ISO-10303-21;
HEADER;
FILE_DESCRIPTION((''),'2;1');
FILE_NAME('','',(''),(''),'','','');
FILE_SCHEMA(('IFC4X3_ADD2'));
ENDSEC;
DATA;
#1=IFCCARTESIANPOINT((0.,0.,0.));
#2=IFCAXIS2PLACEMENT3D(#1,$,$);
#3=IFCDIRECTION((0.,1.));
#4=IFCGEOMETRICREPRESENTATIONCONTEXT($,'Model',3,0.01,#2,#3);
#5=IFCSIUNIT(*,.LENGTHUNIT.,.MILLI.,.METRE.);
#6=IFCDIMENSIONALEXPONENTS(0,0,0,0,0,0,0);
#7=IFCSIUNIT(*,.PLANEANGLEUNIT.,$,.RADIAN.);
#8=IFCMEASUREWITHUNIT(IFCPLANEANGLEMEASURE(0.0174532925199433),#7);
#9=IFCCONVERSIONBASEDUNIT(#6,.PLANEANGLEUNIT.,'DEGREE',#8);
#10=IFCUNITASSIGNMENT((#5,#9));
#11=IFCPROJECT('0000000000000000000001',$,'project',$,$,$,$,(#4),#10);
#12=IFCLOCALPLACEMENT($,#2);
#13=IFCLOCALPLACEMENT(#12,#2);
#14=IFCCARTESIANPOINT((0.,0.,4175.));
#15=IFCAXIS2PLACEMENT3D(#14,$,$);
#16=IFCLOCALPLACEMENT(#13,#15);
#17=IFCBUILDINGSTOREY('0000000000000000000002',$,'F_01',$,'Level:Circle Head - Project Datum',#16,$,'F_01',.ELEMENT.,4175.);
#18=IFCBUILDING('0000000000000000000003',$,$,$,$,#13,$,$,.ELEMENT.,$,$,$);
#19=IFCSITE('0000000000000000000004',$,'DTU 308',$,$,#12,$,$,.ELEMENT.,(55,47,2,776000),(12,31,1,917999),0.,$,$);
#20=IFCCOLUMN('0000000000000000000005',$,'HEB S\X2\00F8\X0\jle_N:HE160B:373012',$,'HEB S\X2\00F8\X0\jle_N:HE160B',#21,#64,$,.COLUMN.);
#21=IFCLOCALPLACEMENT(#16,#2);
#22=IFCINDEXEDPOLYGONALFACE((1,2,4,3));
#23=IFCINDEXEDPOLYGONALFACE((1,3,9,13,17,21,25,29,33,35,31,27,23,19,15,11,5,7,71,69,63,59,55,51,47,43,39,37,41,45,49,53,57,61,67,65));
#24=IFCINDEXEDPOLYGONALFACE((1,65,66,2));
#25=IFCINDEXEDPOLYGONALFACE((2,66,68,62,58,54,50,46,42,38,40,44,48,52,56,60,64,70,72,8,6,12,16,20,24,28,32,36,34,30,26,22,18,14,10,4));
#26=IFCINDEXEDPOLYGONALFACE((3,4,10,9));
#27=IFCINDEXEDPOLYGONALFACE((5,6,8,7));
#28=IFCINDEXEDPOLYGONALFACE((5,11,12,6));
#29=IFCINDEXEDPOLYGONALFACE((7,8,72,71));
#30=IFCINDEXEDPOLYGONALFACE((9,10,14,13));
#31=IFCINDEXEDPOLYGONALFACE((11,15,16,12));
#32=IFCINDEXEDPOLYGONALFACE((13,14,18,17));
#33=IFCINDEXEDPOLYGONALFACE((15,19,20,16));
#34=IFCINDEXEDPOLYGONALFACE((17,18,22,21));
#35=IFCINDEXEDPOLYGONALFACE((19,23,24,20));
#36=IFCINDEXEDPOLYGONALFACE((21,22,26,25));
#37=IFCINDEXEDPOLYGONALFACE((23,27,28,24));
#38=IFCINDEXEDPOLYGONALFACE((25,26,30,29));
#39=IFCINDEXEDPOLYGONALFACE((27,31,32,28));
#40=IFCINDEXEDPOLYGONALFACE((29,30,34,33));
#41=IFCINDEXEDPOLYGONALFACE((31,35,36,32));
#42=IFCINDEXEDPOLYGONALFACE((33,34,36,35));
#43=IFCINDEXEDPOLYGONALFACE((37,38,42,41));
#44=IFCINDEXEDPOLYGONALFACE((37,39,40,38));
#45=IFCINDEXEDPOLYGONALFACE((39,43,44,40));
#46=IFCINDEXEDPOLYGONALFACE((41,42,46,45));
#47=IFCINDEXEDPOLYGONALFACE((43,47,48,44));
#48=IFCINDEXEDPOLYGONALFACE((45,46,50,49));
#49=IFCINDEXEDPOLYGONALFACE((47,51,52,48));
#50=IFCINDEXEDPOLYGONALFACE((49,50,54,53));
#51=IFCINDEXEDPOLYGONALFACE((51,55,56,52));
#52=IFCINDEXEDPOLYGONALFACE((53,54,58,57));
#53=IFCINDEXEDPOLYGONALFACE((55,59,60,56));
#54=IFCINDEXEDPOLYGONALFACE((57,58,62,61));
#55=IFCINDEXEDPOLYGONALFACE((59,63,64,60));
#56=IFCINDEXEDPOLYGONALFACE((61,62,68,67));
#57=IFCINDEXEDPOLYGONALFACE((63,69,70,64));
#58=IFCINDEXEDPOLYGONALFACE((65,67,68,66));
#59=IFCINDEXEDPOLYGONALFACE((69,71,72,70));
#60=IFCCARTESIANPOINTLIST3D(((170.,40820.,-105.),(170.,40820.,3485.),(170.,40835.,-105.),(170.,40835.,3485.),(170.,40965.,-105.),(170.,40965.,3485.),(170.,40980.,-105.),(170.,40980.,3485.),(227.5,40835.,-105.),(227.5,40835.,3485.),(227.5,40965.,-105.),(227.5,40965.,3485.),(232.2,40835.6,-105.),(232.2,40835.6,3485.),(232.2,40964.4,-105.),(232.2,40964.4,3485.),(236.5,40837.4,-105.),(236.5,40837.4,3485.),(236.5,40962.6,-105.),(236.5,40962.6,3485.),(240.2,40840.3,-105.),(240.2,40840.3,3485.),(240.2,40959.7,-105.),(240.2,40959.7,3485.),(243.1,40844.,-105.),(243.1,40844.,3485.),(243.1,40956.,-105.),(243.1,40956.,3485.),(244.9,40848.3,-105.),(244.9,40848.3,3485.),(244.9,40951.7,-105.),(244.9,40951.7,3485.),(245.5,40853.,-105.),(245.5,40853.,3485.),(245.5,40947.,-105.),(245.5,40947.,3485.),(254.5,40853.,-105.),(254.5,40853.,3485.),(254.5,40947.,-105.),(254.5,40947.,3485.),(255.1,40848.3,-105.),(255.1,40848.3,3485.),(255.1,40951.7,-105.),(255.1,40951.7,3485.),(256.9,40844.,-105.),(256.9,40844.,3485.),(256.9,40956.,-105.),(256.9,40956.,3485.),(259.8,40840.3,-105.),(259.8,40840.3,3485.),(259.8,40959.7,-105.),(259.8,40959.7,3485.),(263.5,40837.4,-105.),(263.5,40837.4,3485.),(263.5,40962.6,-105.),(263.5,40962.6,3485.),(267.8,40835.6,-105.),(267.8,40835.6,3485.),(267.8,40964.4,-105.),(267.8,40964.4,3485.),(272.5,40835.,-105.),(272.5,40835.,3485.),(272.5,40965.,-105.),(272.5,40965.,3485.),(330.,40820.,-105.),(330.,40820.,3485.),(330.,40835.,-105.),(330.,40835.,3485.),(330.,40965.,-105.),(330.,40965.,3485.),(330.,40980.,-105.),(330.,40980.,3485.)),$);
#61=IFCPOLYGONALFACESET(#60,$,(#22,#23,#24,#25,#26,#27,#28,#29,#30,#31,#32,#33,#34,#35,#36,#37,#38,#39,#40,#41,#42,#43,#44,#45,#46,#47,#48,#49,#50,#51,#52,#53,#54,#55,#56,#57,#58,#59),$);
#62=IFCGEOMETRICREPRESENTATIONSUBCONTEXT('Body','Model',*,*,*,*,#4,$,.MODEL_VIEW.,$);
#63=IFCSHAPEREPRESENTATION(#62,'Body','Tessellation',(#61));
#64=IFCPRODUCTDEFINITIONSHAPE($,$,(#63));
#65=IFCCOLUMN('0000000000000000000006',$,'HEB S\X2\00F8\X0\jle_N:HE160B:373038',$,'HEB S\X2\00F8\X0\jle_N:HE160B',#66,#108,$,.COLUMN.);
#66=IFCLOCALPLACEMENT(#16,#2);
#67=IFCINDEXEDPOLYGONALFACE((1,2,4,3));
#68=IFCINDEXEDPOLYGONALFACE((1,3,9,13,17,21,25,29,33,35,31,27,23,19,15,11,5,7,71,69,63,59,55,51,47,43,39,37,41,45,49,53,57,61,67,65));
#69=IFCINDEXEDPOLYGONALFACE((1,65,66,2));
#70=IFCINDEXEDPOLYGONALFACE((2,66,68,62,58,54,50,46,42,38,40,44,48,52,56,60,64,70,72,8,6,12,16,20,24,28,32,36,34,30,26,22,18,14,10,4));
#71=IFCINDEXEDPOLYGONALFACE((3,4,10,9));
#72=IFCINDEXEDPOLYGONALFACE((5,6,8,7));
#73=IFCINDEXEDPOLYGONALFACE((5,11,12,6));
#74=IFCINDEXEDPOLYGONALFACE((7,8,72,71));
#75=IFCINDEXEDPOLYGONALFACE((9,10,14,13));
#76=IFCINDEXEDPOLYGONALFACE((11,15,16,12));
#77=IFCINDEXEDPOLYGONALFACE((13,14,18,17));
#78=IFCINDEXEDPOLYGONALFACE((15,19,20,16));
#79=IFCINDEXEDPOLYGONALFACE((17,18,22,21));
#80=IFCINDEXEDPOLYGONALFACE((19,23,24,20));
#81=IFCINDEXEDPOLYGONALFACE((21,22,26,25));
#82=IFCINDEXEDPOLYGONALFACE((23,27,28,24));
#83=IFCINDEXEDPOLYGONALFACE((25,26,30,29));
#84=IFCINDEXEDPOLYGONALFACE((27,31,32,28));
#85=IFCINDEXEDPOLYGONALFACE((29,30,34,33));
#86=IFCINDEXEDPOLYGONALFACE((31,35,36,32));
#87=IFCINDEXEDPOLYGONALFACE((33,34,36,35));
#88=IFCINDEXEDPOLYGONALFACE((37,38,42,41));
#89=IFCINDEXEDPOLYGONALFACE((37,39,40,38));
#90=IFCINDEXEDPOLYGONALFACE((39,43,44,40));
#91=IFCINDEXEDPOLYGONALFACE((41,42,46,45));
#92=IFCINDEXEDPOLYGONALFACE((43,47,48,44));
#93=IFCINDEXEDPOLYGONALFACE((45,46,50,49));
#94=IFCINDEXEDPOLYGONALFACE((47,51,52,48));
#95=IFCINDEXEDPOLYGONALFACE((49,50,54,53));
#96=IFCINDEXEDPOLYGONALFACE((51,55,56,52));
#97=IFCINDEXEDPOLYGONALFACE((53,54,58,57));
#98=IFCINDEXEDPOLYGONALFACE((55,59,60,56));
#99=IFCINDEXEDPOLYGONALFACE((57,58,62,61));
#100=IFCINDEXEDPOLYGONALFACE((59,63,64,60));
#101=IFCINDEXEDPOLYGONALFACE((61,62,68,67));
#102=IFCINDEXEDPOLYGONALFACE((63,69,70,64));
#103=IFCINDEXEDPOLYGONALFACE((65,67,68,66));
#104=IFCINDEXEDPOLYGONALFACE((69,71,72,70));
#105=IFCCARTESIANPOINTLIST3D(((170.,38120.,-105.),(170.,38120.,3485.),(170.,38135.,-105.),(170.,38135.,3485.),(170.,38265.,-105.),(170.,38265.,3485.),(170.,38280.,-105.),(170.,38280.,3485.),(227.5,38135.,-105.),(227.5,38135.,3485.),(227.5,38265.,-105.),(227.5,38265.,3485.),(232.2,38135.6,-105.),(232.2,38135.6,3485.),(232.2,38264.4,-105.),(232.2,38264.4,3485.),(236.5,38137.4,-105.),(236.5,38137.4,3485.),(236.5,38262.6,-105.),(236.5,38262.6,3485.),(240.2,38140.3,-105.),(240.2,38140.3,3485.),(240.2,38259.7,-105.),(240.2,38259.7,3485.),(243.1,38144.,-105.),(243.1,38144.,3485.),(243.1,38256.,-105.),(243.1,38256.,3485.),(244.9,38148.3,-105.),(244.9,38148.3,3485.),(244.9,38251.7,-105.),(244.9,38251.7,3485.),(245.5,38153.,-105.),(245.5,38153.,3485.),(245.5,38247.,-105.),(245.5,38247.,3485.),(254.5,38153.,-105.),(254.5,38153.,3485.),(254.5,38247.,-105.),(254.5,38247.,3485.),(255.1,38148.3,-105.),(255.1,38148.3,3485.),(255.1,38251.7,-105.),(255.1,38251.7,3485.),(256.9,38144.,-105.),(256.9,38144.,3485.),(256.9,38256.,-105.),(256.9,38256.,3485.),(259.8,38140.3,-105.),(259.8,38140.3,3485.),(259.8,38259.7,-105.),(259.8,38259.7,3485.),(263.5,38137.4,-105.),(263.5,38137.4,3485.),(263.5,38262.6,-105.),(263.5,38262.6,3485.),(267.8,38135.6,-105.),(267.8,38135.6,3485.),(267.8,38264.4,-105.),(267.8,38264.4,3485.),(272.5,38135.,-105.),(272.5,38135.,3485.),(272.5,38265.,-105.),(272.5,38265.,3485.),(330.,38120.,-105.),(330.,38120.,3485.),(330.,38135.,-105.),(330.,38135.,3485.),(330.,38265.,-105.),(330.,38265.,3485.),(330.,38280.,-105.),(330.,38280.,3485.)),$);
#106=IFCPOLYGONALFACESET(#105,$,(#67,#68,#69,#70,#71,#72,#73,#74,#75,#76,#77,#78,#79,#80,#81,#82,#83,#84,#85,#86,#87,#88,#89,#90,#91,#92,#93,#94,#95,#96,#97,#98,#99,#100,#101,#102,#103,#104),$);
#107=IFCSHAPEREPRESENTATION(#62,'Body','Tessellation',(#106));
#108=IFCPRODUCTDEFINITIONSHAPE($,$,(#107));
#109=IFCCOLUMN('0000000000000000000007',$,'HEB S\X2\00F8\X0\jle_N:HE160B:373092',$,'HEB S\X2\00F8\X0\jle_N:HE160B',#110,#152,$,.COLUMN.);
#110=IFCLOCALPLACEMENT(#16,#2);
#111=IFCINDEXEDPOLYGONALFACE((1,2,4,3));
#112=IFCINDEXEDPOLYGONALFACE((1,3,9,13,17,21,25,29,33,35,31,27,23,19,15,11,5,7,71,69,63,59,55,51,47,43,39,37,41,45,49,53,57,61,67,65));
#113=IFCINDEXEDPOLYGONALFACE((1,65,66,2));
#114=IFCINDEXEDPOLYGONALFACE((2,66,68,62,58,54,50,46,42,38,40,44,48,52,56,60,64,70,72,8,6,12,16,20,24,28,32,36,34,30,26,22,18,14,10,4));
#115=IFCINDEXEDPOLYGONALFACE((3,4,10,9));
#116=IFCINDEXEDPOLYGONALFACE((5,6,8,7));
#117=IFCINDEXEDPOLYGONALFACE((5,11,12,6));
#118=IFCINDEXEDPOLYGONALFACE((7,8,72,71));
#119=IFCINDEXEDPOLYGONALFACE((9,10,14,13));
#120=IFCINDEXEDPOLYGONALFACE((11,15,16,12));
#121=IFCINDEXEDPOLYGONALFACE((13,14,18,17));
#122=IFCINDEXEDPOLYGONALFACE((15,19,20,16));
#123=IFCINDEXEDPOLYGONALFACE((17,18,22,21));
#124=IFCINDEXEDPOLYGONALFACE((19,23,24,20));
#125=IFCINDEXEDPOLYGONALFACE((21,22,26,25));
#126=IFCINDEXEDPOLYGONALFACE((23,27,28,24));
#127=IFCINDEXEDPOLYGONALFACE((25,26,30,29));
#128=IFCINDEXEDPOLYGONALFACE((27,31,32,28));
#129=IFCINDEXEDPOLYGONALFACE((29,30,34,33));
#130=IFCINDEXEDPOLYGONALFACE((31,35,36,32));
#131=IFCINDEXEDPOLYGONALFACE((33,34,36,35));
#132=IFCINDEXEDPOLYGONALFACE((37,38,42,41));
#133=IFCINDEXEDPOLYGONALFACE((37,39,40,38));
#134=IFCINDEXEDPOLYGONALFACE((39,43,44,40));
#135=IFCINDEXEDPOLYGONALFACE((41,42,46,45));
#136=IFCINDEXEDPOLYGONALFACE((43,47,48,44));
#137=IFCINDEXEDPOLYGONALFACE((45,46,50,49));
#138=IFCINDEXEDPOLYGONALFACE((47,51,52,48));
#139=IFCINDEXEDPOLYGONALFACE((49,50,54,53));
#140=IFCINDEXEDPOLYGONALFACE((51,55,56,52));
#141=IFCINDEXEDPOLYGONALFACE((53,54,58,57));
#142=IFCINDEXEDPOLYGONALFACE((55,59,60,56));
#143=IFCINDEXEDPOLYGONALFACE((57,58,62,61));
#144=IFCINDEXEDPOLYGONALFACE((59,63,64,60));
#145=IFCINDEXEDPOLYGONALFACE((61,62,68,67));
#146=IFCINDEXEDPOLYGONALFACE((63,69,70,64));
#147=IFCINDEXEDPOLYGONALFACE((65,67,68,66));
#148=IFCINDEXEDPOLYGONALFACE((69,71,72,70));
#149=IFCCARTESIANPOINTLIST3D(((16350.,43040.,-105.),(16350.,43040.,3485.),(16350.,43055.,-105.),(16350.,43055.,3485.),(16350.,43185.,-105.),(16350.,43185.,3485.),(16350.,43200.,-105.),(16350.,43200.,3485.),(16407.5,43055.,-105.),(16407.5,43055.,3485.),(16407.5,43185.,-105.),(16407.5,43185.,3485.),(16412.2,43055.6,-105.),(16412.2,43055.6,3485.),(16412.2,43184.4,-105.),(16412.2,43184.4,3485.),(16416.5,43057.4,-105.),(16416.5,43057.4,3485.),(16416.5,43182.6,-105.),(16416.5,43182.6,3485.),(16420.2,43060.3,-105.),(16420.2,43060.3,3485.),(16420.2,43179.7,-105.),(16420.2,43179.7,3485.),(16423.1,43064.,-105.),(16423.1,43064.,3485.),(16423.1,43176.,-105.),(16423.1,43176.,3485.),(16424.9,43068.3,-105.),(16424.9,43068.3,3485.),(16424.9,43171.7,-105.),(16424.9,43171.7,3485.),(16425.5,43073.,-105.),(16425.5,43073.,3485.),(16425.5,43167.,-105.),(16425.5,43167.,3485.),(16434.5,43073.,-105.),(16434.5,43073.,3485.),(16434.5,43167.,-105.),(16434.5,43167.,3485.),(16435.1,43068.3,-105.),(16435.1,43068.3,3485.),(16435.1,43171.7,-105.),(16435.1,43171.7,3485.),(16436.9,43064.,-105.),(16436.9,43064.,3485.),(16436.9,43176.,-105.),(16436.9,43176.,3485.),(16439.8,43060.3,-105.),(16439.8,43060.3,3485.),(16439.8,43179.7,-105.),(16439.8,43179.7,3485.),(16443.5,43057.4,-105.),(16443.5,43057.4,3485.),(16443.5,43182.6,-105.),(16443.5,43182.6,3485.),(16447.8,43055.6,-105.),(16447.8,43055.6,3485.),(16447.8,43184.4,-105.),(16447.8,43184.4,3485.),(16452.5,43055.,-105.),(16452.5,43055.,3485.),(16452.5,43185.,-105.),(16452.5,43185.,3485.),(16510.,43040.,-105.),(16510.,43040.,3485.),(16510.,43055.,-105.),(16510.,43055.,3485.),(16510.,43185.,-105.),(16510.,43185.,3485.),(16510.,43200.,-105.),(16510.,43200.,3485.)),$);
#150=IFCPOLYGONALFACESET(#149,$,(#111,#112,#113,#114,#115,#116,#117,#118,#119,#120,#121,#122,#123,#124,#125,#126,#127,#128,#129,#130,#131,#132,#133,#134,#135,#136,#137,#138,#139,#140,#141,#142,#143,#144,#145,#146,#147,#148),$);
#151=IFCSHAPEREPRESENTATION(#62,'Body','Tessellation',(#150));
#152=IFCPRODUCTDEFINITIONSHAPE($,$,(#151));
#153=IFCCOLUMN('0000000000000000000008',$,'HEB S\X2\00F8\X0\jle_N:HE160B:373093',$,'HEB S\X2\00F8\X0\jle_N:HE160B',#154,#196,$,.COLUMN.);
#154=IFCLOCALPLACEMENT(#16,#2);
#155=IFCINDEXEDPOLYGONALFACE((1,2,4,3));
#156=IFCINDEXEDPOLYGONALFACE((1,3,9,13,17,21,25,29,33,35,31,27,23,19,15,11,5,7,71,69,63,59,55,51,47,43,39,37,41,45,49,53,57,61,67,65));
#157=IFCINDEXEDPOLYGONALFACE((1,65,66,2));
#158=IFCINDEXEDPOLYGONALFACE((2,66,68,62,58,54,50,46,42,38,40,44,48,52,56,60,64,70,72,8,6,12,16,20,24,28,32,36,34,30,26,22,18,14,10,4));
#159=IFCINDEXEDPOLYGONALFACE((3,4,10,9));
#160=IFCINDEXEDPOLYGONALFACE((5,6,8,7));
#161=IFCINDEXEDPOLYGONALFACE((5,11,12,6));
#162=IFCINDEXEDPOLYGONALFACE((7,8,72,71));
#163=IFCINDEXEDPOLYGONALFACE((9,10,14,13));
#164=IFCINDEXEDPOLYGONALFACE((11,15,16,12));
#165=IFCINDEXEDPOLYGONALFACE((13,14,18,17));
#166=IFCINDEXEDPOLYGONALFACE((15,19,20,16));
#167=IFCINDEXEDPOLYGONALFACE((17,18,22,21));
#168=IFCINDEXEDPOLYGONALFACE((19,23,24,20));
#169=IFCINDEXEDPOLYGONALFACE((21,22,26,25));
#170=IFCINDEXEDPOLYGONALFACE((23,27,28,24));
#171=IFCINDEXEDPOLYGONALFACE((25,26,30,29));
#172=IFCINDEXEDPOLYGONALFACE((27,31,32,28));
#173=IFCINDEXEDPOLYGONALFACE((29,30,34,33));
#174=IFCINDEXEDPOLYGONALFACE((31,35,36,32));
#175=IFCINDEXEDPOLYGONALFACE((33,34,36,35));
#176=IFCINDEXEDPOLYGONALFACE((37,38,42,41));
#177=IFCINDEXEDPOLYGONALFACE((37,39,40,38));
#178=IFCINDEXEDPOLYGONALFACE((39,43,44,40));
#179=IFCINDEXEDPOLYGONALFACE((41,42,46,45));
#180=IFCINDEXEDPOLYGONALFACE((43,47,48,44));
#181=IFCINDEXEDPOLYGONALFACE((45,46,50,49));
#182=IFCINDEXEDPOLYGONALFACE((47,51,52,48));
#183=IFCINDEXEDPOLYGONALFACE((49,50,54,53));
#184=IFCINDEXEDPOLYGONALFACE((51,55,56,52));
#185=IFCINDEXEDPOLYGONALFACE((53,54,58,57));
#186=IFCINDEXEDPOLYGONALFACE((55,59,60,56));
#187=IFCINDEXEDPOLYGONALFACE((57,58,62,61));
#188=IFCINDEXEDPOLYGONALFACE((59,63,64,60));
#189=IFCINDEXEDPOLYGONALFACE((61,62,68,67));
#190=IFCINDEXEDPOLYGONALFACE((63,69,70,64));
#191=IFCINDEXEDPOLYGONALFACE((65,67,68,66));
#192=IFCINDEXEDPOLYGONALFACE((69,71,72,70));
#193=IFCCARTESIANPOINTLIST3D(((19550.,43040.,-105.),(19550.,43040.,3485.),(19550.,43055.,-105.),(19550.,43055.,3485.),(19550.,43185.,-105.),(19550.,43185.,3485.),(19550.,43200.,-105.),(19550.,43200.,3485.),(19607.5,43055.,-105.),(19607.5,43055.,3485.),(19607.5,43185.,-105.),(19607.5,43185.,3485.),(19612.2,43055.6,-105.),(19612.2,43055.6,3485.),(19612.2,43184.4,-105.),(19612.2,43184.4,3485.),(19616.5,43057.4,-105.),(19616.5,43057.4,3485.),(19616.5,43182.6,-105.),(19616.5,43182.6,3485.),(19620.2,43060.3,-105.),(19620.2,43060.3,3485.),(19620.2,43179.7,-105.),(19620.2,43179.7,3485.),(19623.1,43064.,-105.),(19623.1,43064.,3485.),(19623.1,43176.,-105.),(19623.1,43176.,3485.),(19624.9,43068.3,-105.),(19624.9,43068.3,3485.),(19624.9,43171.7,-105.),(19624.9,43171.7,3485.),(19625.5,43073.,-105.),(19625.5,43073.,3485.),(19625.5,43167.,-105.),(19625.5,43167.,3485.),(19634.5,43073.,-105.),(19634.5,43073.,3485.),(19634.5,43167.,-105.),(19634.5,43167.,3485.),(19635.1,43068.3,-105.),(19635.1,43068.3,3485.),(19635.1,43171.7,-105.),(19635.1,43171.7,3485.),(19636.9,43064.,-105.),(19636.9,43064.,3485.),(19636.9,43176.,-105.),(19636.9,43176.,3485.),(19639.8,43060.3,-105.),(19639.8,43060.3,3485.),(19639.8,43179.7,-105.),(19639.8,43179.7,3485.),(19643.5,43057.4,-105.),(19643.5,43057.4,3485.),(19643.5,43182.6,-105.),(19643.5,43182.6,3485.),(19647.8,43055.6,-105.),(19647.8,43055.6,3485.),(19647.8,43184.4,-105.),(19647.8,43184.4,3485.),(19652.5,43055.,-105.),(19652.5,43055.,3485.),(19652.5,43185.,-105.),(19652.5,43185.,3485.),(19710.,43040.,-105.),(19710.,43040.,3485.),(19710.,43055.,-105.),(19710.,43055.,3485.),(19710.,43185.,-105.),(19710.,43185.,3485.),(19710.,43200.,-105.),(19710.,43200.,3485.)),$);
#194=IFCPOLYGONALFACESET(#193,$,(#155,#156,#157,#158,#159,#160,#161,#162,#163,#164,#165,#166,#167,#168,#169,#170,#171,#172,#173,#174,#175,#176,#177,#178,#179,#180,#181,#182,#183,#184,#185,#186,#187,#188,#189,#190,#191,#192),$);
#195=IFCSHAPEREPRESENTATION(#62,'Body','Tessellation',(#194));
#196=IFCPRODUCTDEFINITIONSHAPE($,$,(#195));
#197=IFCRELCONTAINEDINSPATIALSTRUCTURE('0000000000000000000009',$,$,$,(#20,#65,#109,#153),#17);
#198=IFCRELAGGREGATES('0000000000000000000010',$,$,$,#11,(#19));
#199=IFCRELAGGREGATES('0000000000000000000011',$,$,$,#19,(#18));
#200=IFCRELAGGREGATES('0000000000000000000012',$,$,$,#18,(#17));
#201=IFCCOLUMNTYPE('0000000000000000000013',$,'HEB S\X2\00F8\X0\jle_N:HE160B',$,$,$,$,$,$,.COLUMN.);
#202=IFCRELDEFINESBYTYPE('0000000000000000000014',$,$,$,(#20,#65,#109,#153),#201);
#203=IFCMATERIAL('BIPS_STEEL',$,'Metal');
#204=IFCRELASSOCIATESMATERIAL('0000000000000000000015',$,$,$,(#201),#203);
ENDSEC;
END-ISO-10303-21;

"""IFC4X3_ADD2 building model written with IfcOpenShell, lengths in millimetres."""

from ifc_helpers import new_model, entity, si_unit, converted_unit, direction, frame, frame_2d, origin, place, context, subcontext, project, spatial, i_section, extrude, source, transform, mapped, material, material_profile, profile_set, type_object, element, save


model = new_model("IFC4X3_ADD2")

# Units and contexts
model_context = context("Model", 3, precision=0.01, world=origin(), true_north=direction((0.0, 1.0)))
body_context = subcontext(model_context, "Body", "Model", "MODEL_VIEW")
ifc_project = project(units=[si_unit("LENGTHUNIT", "METRE", prefix="MILLI"), converted_unit("PLANEANGLEUNIT", "DEGREE", entity("IfcPlaneAngleMeasure", 0.0174532925199433), si_unit("PLANEANGLEUNIT", "RADIAN"), dimensions=[0, 0, 0, 0, 0, 0, 0])], contexts=[model_context])

# Site, building, storey
site_placement = place(None, origin())
site = spatial("IfcSite", under=ifc_project, at=site_placement, Name="DTU 308", CompositionType="ELEMENT", RefLatitude=(55, 47, 2, 776000), RefLongitude=(12, 31, 1, 917999), RefElevation=0.0)
building_placement = place(site_placement, origin())
building = spatial("IfcBuilding", under=site, at=building_placement, CompositionType="ELEMENT")
storey_placement = place(building_placement, frame((0.0, 0.0, 4175.0)))
storey = spatial("IfcBuildingStorey", under=building, at=storey_placement, Name="F_01", ObjectType="Level:Circle Head - Project Datum", LongName="F_01", CompositionType="ELEMENT", Elevation=4175.0)

# Columns
ifc_material_1 = material(Name="BIPS_STEEL", Category="Metal")
ifc_material_profile_1 = material_profile(ifc_material_1, i_section(OverallWidth=160.0, OverallDepth=160.0, WebThickness=9.0, FlangeThickness=15.0, FilletRadius=18.0, at=frame_2d((0.0, 0.0), x_axis=(1.0, 0.0))), Name="HE160B")
ifc_profile_set_1 = profile_set([ifc_material_profile_1], Name="HE160B")
column_type_1 = type_object("IfcColumnType", Name="HEB Søjle_N:HE160B", PredefinedType="COLUMN", material=ifc_profile_set_1)
shared_shape_1 = source(origin(), body_context, "Body", "SweptSolid", [
    extrude(i_section(OverallWidth=160.0, OverallDepth=160.0, WebThickness=9.0, FlangeThickness=15.0, FilletRadius=18.0, at=frame_2d((0.0, 0.0), x_axis=(1.0, 0.0))), frame((0.0, 0.0, 4070.0), z_axis=(0.0, 0.0, 1.0), x_axis=(-1.0, 0.0, 0.0)), (0.0, 0.0, 1.0), 3590.0),
])
for number, where, name in (
    (1, (250.0, 40900.0, -4175.0), "HEB Søjle_N:HE160B:373012"),
    (2, (250.0, 38200.0, -4175.0), "HEB Søjle_N:HE160B:373038"),
    (3, (16430.0, 43120.0, -4175.0), "HEB Søjle_N:HE160B:373092"),
    (4, (19630.0, 43120.0, -4175.0), "HEB Søjle_N:HE160B:373093"),
):
    element("IfcColumn", number, at=place(storey_placement, frame(where)), inside=storey, type_object=column_type_1, Name=name, ObjectType="HEB Søjle_N:HE160B", PredefinedType="COLUMN", context=body_context, shape_type="MappedRepresentation", body=[
        mapped(shared_shape_1, transform((0.0, 0.0, 0.0), scale=1.0)),
    ])

save(model, "model.ifc")
